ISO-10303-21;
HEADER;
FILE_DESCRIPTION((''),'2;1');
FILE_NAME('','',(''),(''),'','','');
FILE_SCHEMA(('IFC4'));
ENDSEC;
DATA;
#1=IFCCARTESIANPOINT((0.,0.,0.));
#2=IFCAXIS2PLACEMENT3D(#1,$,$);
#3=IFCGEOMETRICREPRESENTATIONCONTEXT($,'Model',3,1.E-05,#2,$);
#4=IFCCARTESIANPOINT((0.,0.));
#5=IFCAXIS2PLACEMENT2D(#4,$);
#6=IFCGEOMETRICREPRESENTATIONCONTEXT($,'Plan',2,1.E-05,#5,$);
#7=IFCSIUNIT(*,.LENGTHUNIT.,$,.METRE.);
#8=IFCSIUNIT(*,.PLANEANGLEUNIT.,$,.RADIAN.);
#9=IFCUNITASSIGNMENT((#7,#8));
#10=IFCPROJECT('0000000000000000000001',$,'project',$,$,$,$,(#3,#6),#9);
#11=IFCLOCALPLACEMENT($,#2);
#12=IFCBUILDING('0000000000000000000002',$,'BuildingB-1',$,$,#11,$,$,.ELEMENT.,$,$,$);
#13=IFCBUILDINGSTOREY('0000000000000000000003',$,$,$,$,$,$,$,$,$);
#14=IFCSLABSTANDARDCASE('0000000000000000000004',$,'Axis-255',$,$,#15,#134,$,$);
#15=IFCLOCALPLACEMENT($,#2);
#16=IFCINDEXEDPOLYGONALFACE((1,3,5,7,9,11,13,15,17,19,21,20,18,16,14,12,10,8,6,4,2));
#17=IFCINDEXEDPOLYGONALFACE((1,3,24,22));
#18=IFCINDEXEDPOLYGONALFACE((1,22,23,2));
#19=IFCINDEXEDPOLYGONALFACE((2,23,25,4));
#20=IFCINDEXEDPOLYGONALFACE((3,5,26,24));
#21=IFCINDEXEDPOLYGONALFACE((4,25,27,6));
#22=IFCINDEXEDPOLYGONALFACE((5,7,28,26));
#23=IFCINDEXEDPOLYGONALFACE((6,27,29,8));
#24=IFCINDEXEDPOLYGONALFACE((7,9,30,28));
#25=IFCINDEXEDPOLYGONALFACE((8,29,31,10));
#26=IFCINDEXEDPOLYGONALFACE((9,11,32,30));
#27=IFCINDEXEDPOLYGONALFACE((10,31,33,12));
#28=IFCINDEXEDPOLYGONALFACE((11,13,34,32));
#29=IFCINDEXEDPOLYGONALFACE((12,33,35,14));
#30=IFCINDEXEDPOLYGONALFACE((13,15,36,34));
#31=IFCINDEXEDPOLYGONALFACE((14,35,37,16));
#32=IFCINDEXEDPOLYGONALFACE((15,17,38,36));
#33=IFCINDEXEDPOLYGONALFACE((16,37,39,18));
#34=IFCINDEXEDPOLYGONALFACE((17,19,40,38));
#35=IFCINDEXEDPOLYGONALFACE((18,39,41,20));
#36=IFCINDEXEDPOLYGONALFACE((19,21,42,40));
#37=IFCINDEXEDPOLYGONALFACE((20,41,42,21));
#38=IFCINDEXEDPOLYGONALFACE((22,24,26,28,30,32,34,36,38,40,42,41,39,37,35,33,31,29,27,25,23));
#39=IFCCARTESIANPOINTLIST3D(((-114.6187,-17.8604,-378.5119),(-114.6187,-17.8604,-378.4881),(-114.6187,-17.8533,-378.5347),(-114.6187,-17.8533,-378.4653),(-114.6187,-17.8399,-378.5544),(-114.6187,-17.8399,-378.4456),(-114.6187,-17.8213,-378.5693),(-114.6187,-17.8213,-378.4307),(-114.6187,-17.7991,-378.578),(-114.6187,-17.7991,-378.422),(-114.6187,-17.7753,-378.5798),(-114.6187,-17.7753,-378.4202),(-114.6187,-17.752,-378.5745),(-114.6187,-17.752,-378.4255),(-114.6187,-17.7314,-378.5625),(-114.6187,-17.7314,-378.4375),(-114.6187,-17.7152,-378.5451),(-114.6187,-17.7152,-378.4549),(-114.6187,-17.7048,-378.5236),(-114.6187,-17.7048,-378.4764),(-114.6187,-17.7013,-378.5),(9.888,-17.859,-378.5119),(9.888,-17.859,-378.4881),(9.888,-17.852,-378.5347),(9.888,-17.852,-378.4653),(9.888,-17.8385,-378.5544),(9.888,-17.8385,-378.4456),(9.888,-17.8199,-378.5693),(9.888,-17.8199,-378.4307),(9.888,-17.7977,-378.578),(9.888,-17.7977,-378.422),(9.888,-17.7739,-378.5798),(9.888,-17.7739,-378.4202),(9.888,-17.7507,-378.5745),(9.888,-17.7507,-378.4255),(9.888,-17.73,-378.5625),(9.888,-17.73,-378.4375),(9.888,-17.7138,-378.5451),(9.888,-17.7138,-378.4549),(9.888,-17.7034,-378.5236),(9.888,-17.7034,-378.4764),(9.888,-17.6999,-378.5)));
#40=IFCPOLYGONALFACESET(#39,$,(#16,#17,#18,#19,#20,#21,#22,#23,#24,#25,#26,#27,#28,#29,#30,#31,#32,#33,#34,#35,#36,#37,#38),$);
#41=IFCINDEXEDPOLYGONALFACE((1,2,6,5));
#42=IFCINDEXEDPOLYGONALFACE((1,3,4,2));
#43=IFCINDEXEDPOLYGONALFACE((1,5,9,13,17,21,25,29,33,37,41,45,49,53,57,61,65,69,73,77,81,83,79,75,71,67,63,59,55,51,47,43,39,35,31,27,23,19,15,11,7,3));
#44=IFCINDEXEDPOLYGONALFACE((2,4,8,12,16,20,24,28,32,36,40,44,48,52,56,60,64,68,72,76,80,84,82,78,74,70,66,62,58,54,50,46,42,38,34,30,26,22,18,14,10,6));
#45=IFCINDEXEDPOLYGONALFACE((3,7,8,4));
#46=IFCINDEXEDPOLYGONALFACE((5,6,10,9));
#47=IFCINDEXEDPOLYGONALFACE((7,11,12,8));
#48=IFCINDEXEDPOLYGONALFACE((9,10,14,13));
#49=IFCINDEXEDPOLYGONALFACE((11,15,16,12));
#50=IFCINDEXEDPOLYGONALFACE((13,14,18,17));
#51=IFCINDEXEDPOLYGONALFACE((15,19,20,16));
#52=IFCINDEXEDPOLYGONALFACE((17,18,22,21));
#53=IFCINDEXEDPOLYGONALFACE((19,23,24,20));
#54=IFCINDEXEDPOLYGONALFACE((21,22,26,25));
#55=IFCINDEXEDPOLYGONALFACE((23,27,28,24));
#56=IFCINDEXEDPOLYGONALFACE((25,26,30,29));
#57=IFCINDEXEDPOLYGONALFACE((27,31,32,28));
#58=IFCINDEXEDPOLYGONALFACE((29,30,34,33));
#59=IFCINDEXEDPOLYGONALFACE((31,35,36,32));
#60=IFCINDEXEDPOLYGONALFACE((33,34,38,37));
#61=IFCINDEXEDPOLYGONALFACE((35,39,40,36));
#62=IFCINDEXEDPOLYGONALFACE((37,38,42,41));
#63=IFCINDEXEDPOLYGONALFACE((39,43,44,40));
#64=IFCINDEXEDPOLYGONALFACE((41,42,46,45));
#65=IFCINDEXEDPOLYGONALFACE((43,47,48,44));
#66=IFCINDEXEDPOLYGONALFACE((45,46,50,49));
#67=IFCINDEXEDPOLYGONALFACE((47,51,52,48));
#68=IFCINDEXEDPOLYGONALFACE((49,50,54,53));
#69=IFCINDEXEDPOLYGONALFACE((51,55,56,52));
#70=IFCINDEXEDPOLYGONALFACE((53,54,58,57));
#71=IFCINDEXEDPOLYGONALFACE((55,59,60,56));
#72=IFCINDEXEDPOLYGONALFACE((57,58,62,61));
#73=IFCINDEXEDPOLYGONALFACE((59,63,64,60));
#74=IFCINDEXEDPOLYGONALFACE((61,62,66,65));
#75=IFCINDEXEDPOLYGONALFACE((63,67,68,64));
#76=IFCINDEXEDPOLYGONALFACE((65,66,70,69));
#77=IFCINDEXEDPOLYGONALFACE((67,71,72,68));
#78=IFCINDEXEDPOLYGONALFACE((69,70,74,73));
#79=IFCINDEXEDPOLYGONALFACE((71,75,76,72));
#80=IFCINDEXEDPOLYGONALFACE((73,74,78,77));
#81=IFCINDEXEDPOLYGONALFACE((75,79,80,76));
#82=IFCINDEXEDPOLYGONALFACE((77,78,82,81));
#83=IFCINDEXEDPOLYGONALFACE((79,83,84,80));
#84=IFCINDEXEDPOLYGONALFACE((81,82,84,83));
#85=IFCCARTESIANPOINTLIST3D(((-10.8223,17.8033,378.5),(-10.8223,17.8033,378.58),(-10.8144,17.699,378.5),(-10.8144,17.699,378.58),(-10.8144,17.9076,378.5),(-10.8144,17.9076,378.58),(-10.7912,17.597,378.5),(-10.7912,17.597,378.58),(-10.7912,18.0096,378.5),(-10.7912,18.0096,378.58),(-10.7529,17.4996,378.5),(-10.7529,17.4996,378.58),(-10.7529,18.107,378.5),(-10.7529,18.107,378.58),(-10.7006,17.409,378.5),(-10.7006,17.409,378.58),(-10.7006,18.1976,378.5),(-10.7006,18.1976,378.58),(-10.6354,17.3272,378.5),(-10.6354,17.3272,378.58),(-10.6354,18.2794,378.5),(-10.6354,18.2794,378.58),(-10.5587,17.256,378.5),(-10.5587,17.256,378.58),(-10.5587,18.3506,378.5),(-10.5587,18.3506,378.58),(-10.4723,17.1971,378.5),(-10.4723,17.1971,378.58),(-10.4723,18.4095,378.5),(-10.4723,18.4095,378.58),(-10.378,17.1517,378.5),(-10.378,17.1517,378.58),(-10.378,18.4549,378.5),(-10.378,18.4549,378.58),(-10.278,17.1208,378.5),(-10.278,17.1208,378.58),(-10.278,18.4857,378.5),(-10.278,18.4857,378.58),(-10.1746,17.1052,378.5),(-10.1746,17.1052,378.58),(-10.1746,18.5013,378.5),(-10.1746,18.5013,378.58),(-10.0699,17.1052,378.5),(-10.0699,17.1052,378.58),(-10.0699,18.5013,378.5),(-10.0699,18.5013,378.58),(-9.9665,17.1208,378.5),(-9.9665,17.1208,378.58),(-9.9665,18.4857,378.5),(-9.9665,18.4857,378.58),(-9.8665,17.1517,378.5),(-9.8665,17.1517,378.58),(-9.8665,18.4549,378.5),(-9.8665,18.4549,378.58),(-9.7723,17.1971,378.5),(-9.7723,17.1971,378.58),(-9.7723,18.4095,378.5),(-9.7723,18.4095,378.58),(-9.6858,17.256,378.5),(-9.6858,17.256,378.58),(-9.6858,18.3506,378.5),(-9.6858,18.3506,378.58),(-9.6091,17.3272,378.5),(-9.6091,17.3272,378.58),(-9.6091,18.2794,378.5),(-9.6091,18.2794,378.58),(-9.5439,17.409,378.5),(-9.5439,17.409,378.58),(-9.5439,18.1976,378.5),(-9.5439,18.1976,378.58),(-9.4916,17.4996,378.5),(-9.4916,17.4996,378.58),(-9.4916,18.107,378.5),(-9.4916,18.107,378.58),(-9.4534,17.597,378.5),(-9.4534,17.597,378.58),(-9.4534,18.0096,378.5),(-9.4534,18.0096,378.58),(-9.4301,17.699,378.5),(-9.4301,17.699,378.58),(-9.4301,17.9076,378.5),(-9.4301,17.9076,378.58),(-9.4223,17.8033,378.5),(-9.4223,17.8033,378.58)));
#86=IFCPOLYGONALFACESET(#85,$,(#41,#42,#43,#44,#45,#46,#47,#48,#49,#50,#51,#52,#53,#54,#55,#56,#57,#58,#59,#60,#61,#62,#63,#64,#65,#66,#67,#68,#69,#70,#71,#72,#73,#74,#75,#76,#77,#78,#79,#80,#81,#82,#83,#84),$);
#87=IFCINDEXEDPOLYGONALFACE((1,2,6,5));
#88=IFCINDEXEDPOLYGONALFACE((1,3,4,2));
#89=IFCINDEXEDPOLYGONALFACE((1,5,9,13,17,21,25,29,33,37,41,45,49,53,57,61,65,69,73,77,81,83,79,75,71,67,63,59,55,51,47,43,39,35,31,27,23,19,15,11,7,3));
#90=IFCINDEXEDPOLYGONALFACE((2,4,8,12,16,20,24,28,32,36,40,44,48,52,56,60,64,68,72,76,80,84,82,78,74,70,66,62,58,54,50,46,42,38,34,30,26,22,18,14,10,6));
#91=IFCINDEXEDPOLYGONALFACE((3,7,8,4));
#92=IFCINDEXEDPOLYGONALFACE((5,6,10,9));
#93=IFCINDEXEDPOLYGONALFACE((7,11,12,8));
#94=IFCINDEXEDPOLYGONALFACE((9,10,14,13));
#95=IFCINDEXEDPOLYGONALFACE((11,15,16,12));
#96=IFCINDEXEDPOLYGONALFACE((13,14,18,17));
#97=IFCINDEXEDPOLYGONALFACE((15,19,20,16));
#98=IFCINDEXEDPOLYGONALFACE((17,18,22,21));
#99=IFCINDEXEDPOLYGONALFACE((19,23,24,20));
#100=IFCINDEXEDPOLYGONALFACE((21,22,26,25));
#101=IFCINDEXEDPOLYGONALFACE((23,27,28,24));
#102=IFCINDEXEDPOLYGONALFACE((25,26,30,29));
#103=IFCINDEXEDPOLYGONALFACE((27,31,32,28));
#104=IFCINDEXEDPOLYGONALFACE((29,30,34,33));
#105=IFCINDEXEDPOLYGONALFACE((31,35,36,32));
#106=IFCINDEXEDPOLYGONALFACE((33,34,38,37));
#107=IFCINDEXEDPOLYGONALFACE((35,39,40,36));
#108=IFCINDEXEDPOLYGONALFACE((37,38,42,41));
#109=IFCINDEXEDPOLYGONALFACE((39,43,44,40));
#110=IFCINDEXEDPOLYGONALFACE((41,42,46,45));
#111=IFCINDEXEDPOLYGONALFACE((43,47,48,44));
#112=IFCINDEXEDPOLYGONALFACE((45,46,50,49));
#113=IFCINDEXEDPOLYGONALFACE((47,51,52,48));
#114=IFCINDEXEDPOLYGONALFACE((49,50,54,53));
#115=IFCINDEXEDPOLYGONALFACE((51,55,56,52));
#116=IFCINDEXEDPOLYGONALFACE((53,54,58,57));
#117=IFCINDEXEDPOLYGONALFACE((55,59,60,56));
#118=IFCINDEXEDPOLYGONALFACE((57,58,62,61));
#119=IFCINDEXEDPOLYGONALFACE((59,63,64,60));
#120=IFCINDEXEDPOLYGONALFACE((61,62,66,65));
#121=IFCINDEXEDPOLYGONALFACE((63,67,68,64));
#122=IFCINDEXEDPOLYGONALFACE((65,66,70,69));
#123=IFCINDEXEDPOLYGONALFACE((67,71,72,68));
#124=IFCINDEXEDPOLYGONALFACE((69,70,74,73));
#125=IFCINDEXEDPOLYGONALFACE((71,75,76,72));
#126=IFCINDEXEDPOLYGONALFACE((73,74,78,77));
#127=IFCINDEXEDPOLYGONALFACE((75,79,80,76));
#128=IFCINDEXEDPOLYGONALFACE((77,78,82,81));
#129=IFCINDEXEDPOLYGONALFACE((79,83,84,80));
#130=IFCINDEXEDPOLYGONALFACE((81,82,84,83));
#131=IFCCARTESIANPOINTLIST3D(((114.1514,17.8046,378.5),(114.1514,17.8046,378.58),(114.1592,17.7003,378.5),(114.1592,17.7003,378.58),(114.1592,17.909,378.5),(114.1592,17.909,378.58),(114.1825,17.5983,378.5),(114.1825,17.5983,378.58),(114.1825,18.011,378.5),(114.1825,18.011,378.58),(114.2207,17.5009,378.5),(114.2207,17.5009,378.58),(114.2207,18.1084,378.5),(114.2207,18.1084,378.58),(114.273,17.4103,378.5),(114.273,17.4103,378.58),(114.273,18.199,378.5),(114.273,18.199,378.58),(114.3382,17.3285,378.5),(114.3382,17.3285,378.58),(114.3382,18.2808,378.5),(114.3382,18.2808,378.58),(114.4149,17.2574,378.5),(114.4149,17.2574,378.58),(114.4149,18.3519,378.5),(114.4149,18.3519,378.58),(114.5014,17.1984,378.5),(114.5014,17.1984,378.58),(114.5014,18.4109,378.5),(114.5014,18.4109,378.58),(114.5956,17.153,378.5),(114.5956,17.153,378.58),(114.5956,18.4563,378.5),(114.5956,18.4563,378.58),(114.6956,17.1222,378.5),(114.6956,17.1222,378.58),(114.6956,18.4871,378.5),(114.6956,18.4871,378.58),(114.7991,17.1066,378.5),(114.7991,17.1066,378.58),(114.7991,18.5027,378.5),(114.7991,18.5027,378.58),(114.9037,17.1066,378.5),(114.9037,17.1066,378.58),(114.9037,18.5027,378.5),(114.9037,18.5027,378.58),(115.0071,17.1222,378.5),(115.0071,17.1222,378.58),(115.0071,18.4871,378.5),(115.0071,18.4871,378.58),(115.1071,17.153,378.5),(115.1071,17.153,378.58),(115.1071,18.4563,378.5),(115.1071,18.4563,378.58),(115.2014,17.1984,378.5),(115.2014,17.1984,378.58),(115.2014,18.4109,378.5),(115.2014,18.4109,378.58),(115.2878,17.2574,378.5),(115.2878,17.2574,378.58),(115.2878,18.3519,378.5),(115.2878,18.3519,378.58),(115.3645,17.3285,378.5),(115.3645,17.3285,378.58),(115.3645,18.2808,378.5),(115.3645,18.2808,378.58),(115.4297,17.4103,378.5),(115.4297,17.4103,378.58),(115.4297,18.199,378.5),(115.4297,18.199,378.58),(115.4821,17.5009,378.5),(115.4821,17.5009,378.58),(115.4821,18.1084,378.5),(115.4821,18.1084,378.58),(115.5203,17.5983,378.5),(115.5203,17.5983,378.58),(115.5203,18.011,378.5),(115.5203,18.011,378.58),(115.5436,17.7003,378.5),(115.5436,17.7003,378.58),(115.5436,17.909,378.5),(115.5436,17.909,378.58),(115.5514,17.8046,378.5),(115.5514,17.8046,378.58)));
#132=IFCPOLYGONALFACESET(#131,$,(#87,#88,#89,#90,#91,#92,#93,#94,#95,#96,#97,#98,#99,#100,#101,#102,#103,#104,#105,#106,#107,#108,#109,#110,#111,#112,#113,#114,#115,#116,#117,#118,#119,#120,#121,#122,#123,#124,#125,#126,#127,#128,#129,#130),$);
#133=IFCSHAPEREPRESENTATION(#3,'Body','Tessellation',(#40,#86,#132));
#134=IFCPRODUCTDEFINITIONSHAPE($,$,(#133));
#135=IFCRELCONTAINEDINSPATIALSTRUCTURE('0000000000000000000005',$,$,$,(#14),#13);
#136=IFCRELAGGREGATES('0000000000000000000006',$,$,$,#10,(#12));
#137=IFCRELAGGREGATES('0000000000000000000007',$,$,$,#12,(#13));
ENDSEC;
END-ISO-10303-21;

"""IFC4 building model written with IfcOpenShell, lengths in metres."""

from ifc_helpers import new_model, entity, si_unit, frame, origin, origin_2d, place, context, project, spatial, circle, extrude, element, save


model = new_model("IFC4")

# Units and contexts
model_context = context("Model", 3, precision=1e-05, world=origin())
plan_context = context("Plan", 2, precision=1e-05, world=origin_2d())
ifc_project = project(units=[si_unit("LENGTHUNIT", "METRE"), si_unit("PLANEANGLEUNIT", "RADIAN")], contexts=[model_context, plan_context])

# Building, storey
building_placement = place(None, origin())
building = spatial("IfcBuilding", under=ifc_project, at=building_placement, Name="BuildingB-1", CompositionType="ELEMENT")
storey = spatial("IfcBuildingStorey", under=building)

# Slab
element("IfcSlabStandardCase", 1, inside=storey, Name="Axis-255", context=model_context, shape_type="AdvancedSweptSolid", body=[
    entity("IfcSurfaceCurveSweptAreaSolid", entity("IfcCircleProfileDef", "AREA", None, None, 0.08), None, entity("IfcPolyline", [entity("IfcCartesianPoint", [-9.888, 17.7799, 378.5]), entity("IfcCartesianPoint", [114.6187, 17.7813, 378.5])]), None, None, entity("IfcPlane", entity("IfcAxis2Placement3D", entity("IfcCartesianPoint", [-9.888, 17.7799, 378.5]), entity("IfcDirection", [0.0, 0.0, 1.0]), entity("IfcDirection", [1.0, 0.0, 0.0])))),
    extrude(circle(Radius=0.7), frame((-10.1223, 17.8033, 378.5)), (0.0, 0.0, 1.0), 0.08),
    extrude(circle(Radius=0.7), frame((114.8514, 17.8046, 378.5)), (0.0, 0.0, 1.0), 0.08),
])

save(model, "model.ifc")
